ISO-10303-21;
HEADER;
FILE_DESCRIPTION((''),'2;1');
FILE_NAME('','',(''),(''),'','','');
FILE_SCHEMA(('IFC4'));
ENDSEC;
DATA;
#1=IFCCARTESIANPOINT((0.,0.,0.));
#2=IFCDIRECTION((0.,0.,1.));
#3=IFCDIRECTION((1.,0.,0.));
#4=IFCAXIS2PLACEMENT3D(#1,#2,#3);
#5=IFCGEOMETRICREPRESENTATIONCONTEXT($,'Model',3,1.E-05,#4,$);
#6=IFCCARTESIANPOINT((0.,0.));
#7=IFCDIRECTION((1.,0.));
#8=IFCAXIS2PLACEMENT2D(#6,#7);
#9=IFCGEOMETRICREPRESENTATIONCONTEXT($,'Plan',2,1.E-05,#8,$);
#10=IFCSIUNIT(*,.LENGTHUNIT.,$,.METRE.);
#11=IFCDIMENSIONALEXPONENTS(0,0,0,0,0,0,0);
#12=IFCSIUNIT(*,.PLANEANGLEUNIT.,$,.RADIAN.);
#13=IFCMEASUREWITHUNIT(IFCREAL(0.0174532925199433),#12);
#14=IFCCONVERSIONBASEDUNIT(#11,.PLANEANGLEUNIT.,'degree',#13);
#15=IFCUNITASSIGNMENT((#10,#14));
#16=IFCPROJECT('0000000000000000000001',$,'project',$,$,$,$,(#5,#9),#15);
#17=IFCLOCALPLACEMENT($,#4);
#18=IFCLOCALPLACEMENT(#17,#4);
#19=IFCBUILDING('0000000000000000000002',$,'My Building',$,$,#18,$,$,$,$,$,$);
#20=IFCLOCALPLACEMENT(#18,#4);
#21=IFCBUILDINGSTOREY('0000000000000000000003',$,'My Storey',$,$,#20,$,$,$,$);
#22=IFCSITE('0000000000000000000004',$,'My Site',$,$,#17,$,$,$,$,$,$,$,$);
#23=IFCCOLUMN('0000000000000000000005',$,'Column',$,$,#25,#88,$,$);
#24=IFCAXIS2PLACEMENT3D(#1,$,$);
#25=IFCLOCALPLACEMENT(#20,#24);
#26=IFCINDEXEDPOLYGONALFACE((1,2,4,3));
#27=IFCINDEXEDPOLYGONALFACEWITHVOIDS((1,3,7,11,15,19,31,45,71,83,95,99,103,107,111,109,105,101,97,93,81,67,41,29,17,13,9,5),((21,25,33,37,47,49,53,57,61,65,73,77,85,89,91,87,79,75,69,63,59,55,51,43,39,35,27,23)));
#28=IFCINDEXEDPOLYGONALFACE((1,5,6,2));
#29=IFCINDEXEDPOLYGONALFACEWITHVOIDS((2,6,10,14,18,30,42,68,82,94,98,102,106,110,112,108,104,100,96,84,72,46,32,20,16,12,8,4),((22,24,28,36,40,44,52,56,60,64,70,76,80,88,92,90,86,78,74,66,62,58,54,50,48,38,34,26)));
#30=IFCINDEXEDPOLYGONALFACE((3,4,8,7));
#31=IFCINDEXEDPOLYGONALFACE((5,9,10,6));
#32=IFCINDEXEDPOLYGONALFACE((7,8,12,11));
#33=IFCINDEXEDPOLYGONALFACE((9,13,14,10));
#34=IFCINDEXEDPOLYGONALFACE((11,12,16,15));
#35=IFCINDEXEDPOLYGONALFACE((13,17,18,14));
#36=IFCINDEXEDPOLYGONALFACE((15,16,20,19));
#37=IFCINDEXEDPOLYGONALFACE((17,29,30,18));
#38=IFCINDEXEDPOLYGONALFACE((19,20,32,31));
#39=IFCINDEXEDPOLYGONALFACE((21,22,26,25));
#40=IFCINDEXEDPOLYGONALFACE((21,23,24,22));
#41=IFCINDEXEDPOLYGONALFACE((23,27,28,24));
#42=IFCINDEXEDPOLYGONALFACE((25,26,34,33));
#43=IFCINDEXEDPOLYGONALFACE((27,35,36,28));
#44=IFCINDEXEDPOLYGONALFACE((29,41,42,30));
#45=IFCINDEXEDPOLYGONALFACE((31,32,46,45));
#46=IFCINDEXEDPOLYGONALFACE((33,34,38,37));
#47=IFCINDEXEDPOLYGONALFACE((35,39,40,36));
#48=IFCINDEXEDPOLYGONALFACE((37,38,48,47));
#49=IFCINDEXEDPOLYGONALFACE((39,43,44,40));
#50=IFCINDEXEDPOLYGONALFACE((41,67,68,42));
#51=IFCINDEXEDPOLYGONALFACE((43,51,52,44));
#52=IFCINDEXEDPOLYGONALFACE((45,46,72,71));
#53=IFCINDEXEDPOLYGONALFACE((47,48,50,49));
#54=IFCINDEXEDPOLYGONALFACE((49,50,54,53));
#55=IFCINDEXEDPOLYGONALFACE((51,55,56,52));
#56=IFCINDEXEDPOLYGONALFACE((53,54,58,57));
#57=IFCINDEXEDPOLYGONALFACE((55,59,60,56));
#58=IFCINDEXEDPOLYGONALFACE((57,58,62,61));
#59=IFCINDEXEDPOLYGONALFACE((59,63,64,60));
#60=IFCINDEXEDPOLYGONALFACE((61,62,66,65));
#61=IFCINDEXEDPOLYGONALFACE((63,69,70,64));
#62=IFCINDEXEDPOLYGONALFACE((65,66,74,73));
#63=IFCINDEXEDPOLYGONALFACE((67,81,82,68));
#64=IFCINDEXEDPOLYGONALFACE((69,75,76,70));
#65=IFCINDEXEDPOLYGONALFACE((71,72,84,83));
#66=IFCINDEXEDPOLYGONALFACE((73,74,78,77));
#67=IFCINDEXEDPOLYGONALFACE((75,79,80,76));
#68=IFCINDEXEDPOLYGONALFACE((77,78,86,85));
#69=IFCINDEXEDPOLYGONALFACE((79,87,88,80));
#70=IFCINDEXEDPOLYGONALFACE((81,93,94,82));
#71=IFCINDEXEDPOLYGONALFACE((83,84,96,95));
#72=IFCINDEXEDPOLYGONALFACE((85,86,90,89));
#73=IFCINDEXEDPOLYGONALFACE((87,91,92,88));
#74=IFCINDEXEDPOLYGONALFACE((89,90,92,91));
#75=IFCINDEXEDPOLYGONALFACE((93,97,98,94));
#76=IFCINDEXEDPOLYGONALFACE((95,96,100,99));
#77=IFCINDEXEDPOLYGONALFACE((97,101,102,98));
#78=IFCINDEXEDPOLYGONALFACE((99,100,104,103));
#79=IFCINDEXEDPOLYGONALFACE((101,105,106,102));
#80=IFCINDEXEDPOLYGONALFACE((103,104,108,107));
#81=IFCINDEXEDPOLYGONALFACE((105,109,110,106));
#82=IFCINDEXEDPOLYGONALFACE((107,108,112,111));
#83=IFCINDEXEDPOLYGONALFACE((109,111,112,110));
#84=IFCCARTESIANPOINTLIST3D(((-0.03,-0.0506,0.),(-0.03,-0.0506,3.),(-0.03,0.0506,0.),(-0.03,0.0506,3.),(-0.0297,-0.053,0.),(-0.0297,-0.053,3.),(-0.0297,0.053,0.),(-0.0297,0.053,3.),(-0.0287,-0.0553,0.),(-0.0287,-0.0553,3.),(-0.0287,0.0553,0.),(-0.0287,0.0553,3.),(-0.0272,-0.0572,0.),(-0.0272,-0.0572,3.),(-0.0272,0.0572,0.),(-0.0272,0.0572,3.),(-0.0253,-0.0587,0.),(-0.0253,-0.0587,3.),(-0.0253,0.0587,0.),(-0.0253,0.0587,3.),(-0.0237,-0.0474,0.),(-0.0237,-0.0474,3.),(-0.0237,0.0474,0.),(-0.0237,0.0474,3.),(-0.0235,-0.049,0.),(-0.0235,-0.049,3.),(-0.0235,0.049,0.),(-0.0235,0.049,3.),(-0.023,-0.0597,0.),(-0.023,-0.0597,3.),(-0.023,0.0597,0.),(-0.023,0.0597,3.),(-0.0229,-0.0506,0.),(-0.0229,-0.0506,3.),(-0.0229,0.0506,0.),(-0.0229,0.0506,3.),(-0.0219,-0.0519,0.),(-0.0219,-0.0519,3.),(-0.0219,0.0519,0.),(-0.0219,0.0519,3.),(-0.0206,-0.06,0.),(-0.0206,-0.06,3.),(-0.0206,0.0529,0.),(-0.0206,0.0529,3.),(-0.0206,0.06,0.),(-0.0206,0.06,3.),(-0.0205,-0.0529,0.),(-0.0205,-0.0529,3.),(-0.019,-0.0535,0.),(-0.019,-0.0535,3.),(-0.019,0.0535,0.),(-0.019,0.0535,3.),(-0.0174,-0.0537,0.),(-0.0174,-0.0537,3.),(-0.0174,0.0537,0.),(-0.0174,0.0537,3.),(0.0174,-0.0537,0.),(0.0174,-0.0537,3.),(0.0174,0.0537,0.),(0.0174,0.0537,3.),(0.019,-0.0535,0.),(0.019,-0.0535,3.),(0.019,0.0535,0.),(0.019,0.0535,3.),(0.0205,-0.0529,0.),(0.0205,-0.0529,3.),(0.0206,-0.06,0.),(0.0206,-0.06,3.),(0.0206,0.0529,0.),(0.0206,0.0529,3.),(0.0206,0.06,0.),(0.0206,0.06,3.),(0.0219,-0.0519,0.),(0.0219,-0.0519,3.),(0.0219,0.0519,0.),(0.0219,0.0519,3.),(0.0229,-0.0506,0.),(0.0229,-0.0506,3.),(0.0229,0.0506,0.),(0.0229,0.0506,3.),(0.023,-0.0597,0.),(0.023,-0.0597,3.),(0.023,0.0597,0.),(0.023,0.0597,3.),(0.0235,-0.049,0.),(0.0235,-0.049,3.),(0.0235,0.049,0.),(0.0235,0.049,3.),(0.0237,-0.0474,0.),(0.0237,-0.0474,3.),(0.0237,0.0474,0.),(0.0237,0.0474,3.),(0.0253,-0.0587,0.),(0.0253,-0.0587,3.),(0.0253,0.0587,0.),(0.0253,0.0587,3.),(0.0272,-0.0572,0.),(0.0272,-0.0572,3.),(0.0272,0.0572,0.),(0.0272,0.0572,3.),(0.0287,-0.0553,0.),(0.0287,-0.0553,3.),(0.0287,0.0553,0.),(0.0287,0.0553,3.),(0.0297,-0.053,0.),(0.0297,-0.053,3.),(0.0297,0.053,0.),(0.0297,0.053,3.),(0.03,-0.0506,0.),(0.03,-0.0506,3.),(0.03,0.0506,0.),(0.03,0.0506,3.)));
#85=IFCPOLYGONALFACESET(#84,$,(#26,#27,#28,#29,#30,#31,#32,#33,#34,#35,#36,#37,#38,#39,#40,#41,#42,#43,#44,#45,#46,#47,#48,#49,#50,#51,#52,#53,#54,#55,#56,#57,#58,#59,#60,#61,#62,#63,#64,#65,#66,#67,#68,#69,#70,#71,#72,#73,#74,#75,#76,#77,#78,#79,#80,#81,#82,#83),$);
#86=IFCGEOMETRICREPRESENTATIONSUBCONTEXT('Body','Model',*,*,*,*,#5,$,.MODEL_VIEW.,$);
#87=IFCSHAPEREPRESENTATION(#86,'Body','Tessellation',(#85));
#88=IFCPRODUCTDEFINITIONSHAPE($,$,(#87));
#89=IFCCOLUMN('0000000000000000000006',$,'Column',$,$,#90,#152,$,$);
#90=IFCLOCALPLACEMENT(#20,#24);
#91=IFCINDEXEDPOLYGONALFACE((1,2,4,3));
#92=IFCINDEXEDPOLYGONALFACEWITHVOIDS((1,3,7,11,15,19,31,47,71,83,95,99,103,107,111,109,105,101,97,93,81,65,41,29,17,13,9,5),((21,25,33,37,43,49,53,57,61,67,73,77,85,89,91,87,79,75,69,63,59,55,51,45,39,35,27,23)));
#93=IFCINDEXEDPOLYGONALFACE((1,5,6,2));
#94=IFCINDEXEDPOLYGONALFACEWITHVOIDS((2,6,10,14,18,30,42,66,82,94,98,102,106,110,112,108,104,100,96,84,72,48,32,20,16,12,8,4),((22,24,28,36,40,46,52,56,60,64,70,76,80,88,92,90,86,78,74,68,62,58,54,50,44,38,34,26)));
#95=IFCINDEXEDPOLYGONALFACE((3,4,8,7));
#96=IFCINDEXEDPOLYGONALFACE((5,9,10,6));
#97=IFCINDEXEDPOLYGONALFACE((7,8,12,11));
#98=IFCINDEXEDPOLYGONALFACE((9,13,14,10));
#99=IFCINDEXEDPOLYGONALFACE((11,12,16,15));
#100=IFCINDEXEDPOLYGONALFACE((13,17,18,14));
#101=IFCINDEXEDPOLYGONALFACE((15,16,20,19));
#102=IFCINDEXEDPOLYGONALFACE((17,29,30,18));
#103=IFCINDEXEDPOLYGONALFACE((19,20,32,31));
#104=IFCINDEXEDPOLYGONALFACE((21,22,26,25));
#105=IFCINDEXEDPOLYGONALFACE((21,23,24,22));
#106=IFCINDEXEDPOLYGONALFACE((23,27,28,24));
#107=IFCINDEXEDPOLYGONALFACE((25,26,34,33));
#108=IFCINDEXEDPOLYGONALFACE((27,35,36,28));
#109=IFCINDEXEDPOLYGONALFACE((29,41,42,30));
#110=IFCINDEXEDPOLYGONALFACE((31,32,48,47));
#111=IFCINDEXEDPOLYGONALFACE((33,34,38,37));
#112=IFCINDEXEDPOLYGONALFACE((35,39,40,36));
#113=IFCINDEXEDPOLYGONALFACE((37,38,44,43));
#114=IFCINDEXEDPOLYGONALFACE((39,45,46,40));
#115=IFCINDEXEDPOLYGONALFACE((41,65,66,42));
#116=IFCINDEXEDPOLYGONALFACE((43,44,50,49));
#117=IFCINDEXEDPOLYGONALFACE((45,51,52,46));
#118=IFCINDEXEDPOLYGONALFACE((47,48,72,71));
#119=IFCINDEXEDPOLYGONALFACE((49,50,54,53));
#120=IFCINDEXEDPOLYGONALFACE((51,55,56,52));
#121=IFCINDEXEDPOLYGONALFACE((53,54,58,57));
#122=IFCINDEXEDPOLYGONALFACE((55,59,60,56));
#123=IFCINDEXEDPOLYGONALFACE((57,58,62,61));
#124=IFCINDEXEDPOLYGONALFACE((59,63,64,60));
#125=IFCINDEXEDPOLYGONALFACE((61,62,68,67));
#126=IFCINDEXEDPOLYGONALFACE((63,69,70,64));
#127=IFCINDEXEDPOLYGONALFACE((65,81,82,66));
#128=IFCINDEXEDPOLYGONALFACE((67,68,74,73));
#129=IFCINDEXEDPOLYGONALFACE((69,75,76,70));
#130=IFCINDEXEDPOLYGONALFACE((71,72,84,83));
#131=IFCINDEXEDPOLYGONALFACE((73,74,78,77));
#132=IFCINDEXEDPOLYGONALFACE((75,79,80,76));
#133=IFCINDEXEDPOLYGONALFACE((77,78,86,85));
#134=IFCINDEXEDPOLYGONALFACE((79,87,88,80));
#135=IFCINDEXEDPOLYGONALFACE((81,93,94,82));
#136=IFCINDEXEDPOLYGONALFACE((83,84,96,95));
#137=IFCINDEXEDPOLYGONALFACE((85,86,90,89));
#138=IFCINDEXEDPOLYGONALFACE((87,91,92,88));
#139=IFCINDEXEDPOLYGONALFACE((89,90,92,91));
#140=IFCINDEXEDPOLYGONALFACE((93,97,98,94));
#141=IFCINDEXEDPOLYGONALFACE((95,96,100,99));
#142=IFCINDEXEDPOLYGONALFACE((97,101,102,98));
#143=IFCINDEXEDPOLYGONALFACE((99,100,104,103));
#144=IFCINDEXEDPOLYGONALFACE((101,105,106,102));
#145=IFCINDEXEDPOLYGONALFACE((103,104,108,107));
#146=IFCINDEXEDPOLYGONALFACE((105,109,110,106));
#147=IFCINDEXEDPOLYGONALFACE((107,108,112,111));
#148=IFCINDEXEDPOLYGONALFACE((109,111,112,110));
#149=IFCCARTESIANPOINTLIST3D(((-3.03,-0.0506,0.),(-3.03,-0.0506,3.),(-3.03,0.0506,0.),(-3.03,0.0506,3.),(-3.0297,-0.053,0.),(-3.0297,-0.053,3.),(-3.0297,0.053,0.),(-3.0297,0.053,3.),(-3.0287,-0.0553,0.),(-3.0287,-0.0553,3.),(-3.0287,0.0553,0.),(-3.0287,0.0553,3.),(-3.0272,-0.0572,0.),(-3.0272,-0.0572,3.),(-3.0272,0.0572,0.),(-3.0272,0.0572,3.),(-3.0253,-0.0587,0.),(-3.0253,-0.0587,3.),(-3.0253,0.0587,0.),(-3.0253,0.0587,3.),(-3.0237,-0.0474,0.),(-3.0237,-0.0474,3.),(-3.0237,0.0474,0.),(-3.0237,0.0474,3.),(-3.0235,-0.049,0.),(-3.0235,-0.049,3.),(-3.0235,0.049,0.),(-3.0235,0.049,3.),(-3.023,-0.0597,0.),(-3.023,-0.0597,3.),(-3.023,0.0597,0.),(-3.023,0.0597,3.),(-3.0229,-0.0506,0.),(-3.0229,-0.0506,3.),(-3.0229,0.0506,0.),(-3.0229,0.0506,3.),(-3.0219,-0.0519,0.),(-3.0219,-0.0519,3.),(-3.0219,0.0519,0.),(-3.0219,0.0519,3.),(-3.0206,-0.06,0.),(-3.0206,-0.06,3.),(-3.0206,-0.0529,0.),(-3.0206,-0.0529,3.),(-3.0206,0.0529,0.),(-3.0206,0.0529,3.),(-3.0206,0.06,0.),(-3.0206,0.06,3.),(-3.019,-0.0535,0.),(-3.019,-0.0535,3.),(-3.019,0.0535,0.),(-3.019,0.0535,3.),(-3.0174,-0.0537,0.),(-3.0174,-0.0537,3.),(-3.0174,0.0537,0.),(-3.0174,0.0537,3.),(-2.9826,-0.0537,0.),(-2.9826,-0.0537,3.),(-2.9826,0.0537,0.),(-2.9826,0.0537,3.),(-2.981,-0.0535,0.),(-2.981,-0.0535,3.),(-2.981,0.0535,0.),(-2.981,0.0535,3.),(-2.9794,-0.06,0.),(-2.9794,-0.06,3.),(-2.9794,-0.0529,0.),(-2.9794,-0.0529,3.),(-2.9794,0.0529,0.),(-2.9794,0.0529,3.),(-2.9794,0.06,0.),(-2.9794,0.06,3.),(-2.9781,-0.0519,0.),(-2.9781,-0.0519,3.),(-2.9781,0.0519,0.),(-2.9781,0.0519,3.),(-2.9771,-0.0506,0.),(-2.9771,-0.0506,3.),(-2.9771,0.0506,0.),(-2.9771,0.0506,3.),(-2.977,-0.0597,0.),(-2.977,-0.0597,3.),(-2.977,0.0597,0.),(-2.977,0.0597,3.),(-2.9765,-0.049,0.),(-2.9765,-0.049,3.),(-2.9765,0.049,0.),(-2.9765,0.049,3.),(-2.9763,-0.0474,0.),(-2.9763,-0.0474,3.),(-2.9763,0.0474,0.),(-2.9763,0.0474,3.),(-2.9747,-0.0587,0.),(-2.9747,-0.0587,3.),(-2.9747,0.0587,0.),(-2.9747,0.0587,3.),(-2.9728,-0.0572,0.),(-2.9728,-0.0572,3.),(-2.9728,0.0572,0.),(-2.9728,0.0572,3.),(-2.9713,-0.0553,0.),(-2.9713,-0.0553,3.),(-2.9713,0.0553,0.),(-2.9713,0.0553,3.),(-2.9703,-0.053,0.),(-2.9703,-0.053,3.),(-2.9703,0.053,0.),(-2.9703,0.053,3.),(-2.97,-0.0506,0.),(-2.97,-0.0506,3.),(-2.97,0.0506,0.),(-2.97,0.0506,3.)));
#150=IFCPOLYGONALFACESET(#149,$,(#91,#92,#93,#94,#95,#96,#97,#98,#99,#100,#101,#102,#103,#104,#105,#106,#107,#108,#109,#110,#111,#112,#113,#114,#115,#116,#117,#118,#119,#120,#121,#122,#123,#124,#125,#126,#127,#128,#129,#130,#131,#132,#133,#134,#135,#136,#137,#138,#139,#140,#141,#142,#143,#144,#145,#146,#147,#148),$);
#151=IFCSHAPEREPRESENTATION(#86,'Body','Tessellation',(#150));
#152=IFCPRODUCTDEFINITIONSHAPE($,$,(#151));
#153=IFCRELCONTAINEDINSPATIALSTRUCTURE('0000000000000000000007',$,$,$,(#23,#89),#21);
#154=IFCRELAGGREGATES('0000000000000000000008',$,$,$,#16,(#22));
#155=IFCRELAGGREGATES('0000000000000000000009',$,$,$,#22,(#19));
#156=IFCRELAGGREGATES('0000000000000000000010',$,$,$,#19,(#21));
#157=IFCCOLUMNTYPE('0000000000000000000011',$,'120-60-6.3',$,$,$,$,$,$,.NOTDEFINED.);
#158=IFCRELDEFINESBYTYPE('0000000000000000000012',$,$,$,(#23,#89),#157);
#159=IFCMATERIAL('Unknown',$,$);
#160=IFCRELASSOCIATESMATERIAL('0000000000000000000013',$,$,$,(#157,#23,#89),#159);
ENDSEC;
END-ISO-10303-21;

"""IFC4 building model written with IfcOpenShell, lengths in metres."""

from ifc_helpers import new_model, entity, si_unit, converted_unit, frame, origin_with_axes, origin_2d_with_axis, place, context, subcontext, project, spatial, hollow_rectangle, extrude, material, material_profile, profile_set, profile_usage, type_object, element, save


model = new_model("IFC4")

# Units and contexts
model_context = context("Model", 3, precision=1e-05, world=origin_with_axes())
plan_context = context("Plan", 2, precision=1e-05, world=origin_2d_with_axis())
body_context = subcontext(model_context, "Body", "Model", "MODEL_VIEW")
ifc_project = project(units=[si_unit("LENGTHUNIT", "METRE"), converted_unit("PLANEANGLEUNIT", "degree", entity("IfcReal", 0.0174532925199433), si_unit("PLANEANGLEUNIT", "RADIAN"), dimensions=[0, 0, 0, 0, 0, 0, 0])], contexts=[model_context, plan_context])

# Site, building, storey
site_placement = place(None, origin_with_axes())
site = spatial("IfcSite", under=ifc_project, at=site_placement, Name="My Site")
building_placement = place(site_placement, origin_with_axes())
building = spatial("IfcBuilding", under=site, at=building_placement, Name="My Building")
storey_placement = place(building_placement, origin_with_axes())
storey = spatial("IfcBuildingStorey", under=building, at=storey_placement, Name="My Storey")

# Columns
ifc_material = material(Name="Unknown")
ifc_material_profile_1 = material_profile(ifc_material, hollow_rectangle(XDim=0.06, YDim=0.12, WallThickness=0.0063, InnerFilletRadius=0.0063, OuterFilletRadius=0.0095))
ifc_profile_set_1 = profile_set([ifc_material_profile_1])
ifc_profile_usage_1 = profile_usage(ifc_profile_set_1, cardinal=5)
column_type = type_object("IfcColumnType", Name="120-60-6.3", PredefinedType="NOTDEFINED", material=ifc_profile_set_1)
column_1_placement = place(storey_placement, origin_with_axes())
element("IfcColumn", 1, at=column_1_placement, inside=storey, type_object=column_type, material=ifc_profile_usage_1, Name="Column", context=body_context, shape_type="SweptSolid", body=[
    extrude(hollow_rectangle(XDim=0.06, YDim=0.12, WallThickness=0.0063, InnerFilletRadius=0.0063, OuterFilletRadius=0.0095), origin_with_axes(), (0.0, 0.0, 1.0), 3.0),
])
ifc_profile_usage_2 = profile_usage(ifc_profile_set_1, cardinal=5)
column_2_placement = place(storey_placement, frame((-3.0, 0.0, 0.0), z_axis=(0.0, 0.0, 1.0), x_axis=(1.0, 0.0, 0.0)))
element("IfcColumn", 2, at=column_2_placement, inside=storey, type_object=column_type, material=ifc_profile_usage_2, Name="Column", context=body_context, shape_type="SweptSolid", body=[
    extrude(hollow_rectangle(XDim=0.06, YDim=0.12, WallThickness=0.0063, InnerFilletRadius=0.0063, OuterFilletRadius=0.0095), origin_with_axes(), (0.0, 0.0, 1.0), 3.0),
])

save(model, "model.ifc")
